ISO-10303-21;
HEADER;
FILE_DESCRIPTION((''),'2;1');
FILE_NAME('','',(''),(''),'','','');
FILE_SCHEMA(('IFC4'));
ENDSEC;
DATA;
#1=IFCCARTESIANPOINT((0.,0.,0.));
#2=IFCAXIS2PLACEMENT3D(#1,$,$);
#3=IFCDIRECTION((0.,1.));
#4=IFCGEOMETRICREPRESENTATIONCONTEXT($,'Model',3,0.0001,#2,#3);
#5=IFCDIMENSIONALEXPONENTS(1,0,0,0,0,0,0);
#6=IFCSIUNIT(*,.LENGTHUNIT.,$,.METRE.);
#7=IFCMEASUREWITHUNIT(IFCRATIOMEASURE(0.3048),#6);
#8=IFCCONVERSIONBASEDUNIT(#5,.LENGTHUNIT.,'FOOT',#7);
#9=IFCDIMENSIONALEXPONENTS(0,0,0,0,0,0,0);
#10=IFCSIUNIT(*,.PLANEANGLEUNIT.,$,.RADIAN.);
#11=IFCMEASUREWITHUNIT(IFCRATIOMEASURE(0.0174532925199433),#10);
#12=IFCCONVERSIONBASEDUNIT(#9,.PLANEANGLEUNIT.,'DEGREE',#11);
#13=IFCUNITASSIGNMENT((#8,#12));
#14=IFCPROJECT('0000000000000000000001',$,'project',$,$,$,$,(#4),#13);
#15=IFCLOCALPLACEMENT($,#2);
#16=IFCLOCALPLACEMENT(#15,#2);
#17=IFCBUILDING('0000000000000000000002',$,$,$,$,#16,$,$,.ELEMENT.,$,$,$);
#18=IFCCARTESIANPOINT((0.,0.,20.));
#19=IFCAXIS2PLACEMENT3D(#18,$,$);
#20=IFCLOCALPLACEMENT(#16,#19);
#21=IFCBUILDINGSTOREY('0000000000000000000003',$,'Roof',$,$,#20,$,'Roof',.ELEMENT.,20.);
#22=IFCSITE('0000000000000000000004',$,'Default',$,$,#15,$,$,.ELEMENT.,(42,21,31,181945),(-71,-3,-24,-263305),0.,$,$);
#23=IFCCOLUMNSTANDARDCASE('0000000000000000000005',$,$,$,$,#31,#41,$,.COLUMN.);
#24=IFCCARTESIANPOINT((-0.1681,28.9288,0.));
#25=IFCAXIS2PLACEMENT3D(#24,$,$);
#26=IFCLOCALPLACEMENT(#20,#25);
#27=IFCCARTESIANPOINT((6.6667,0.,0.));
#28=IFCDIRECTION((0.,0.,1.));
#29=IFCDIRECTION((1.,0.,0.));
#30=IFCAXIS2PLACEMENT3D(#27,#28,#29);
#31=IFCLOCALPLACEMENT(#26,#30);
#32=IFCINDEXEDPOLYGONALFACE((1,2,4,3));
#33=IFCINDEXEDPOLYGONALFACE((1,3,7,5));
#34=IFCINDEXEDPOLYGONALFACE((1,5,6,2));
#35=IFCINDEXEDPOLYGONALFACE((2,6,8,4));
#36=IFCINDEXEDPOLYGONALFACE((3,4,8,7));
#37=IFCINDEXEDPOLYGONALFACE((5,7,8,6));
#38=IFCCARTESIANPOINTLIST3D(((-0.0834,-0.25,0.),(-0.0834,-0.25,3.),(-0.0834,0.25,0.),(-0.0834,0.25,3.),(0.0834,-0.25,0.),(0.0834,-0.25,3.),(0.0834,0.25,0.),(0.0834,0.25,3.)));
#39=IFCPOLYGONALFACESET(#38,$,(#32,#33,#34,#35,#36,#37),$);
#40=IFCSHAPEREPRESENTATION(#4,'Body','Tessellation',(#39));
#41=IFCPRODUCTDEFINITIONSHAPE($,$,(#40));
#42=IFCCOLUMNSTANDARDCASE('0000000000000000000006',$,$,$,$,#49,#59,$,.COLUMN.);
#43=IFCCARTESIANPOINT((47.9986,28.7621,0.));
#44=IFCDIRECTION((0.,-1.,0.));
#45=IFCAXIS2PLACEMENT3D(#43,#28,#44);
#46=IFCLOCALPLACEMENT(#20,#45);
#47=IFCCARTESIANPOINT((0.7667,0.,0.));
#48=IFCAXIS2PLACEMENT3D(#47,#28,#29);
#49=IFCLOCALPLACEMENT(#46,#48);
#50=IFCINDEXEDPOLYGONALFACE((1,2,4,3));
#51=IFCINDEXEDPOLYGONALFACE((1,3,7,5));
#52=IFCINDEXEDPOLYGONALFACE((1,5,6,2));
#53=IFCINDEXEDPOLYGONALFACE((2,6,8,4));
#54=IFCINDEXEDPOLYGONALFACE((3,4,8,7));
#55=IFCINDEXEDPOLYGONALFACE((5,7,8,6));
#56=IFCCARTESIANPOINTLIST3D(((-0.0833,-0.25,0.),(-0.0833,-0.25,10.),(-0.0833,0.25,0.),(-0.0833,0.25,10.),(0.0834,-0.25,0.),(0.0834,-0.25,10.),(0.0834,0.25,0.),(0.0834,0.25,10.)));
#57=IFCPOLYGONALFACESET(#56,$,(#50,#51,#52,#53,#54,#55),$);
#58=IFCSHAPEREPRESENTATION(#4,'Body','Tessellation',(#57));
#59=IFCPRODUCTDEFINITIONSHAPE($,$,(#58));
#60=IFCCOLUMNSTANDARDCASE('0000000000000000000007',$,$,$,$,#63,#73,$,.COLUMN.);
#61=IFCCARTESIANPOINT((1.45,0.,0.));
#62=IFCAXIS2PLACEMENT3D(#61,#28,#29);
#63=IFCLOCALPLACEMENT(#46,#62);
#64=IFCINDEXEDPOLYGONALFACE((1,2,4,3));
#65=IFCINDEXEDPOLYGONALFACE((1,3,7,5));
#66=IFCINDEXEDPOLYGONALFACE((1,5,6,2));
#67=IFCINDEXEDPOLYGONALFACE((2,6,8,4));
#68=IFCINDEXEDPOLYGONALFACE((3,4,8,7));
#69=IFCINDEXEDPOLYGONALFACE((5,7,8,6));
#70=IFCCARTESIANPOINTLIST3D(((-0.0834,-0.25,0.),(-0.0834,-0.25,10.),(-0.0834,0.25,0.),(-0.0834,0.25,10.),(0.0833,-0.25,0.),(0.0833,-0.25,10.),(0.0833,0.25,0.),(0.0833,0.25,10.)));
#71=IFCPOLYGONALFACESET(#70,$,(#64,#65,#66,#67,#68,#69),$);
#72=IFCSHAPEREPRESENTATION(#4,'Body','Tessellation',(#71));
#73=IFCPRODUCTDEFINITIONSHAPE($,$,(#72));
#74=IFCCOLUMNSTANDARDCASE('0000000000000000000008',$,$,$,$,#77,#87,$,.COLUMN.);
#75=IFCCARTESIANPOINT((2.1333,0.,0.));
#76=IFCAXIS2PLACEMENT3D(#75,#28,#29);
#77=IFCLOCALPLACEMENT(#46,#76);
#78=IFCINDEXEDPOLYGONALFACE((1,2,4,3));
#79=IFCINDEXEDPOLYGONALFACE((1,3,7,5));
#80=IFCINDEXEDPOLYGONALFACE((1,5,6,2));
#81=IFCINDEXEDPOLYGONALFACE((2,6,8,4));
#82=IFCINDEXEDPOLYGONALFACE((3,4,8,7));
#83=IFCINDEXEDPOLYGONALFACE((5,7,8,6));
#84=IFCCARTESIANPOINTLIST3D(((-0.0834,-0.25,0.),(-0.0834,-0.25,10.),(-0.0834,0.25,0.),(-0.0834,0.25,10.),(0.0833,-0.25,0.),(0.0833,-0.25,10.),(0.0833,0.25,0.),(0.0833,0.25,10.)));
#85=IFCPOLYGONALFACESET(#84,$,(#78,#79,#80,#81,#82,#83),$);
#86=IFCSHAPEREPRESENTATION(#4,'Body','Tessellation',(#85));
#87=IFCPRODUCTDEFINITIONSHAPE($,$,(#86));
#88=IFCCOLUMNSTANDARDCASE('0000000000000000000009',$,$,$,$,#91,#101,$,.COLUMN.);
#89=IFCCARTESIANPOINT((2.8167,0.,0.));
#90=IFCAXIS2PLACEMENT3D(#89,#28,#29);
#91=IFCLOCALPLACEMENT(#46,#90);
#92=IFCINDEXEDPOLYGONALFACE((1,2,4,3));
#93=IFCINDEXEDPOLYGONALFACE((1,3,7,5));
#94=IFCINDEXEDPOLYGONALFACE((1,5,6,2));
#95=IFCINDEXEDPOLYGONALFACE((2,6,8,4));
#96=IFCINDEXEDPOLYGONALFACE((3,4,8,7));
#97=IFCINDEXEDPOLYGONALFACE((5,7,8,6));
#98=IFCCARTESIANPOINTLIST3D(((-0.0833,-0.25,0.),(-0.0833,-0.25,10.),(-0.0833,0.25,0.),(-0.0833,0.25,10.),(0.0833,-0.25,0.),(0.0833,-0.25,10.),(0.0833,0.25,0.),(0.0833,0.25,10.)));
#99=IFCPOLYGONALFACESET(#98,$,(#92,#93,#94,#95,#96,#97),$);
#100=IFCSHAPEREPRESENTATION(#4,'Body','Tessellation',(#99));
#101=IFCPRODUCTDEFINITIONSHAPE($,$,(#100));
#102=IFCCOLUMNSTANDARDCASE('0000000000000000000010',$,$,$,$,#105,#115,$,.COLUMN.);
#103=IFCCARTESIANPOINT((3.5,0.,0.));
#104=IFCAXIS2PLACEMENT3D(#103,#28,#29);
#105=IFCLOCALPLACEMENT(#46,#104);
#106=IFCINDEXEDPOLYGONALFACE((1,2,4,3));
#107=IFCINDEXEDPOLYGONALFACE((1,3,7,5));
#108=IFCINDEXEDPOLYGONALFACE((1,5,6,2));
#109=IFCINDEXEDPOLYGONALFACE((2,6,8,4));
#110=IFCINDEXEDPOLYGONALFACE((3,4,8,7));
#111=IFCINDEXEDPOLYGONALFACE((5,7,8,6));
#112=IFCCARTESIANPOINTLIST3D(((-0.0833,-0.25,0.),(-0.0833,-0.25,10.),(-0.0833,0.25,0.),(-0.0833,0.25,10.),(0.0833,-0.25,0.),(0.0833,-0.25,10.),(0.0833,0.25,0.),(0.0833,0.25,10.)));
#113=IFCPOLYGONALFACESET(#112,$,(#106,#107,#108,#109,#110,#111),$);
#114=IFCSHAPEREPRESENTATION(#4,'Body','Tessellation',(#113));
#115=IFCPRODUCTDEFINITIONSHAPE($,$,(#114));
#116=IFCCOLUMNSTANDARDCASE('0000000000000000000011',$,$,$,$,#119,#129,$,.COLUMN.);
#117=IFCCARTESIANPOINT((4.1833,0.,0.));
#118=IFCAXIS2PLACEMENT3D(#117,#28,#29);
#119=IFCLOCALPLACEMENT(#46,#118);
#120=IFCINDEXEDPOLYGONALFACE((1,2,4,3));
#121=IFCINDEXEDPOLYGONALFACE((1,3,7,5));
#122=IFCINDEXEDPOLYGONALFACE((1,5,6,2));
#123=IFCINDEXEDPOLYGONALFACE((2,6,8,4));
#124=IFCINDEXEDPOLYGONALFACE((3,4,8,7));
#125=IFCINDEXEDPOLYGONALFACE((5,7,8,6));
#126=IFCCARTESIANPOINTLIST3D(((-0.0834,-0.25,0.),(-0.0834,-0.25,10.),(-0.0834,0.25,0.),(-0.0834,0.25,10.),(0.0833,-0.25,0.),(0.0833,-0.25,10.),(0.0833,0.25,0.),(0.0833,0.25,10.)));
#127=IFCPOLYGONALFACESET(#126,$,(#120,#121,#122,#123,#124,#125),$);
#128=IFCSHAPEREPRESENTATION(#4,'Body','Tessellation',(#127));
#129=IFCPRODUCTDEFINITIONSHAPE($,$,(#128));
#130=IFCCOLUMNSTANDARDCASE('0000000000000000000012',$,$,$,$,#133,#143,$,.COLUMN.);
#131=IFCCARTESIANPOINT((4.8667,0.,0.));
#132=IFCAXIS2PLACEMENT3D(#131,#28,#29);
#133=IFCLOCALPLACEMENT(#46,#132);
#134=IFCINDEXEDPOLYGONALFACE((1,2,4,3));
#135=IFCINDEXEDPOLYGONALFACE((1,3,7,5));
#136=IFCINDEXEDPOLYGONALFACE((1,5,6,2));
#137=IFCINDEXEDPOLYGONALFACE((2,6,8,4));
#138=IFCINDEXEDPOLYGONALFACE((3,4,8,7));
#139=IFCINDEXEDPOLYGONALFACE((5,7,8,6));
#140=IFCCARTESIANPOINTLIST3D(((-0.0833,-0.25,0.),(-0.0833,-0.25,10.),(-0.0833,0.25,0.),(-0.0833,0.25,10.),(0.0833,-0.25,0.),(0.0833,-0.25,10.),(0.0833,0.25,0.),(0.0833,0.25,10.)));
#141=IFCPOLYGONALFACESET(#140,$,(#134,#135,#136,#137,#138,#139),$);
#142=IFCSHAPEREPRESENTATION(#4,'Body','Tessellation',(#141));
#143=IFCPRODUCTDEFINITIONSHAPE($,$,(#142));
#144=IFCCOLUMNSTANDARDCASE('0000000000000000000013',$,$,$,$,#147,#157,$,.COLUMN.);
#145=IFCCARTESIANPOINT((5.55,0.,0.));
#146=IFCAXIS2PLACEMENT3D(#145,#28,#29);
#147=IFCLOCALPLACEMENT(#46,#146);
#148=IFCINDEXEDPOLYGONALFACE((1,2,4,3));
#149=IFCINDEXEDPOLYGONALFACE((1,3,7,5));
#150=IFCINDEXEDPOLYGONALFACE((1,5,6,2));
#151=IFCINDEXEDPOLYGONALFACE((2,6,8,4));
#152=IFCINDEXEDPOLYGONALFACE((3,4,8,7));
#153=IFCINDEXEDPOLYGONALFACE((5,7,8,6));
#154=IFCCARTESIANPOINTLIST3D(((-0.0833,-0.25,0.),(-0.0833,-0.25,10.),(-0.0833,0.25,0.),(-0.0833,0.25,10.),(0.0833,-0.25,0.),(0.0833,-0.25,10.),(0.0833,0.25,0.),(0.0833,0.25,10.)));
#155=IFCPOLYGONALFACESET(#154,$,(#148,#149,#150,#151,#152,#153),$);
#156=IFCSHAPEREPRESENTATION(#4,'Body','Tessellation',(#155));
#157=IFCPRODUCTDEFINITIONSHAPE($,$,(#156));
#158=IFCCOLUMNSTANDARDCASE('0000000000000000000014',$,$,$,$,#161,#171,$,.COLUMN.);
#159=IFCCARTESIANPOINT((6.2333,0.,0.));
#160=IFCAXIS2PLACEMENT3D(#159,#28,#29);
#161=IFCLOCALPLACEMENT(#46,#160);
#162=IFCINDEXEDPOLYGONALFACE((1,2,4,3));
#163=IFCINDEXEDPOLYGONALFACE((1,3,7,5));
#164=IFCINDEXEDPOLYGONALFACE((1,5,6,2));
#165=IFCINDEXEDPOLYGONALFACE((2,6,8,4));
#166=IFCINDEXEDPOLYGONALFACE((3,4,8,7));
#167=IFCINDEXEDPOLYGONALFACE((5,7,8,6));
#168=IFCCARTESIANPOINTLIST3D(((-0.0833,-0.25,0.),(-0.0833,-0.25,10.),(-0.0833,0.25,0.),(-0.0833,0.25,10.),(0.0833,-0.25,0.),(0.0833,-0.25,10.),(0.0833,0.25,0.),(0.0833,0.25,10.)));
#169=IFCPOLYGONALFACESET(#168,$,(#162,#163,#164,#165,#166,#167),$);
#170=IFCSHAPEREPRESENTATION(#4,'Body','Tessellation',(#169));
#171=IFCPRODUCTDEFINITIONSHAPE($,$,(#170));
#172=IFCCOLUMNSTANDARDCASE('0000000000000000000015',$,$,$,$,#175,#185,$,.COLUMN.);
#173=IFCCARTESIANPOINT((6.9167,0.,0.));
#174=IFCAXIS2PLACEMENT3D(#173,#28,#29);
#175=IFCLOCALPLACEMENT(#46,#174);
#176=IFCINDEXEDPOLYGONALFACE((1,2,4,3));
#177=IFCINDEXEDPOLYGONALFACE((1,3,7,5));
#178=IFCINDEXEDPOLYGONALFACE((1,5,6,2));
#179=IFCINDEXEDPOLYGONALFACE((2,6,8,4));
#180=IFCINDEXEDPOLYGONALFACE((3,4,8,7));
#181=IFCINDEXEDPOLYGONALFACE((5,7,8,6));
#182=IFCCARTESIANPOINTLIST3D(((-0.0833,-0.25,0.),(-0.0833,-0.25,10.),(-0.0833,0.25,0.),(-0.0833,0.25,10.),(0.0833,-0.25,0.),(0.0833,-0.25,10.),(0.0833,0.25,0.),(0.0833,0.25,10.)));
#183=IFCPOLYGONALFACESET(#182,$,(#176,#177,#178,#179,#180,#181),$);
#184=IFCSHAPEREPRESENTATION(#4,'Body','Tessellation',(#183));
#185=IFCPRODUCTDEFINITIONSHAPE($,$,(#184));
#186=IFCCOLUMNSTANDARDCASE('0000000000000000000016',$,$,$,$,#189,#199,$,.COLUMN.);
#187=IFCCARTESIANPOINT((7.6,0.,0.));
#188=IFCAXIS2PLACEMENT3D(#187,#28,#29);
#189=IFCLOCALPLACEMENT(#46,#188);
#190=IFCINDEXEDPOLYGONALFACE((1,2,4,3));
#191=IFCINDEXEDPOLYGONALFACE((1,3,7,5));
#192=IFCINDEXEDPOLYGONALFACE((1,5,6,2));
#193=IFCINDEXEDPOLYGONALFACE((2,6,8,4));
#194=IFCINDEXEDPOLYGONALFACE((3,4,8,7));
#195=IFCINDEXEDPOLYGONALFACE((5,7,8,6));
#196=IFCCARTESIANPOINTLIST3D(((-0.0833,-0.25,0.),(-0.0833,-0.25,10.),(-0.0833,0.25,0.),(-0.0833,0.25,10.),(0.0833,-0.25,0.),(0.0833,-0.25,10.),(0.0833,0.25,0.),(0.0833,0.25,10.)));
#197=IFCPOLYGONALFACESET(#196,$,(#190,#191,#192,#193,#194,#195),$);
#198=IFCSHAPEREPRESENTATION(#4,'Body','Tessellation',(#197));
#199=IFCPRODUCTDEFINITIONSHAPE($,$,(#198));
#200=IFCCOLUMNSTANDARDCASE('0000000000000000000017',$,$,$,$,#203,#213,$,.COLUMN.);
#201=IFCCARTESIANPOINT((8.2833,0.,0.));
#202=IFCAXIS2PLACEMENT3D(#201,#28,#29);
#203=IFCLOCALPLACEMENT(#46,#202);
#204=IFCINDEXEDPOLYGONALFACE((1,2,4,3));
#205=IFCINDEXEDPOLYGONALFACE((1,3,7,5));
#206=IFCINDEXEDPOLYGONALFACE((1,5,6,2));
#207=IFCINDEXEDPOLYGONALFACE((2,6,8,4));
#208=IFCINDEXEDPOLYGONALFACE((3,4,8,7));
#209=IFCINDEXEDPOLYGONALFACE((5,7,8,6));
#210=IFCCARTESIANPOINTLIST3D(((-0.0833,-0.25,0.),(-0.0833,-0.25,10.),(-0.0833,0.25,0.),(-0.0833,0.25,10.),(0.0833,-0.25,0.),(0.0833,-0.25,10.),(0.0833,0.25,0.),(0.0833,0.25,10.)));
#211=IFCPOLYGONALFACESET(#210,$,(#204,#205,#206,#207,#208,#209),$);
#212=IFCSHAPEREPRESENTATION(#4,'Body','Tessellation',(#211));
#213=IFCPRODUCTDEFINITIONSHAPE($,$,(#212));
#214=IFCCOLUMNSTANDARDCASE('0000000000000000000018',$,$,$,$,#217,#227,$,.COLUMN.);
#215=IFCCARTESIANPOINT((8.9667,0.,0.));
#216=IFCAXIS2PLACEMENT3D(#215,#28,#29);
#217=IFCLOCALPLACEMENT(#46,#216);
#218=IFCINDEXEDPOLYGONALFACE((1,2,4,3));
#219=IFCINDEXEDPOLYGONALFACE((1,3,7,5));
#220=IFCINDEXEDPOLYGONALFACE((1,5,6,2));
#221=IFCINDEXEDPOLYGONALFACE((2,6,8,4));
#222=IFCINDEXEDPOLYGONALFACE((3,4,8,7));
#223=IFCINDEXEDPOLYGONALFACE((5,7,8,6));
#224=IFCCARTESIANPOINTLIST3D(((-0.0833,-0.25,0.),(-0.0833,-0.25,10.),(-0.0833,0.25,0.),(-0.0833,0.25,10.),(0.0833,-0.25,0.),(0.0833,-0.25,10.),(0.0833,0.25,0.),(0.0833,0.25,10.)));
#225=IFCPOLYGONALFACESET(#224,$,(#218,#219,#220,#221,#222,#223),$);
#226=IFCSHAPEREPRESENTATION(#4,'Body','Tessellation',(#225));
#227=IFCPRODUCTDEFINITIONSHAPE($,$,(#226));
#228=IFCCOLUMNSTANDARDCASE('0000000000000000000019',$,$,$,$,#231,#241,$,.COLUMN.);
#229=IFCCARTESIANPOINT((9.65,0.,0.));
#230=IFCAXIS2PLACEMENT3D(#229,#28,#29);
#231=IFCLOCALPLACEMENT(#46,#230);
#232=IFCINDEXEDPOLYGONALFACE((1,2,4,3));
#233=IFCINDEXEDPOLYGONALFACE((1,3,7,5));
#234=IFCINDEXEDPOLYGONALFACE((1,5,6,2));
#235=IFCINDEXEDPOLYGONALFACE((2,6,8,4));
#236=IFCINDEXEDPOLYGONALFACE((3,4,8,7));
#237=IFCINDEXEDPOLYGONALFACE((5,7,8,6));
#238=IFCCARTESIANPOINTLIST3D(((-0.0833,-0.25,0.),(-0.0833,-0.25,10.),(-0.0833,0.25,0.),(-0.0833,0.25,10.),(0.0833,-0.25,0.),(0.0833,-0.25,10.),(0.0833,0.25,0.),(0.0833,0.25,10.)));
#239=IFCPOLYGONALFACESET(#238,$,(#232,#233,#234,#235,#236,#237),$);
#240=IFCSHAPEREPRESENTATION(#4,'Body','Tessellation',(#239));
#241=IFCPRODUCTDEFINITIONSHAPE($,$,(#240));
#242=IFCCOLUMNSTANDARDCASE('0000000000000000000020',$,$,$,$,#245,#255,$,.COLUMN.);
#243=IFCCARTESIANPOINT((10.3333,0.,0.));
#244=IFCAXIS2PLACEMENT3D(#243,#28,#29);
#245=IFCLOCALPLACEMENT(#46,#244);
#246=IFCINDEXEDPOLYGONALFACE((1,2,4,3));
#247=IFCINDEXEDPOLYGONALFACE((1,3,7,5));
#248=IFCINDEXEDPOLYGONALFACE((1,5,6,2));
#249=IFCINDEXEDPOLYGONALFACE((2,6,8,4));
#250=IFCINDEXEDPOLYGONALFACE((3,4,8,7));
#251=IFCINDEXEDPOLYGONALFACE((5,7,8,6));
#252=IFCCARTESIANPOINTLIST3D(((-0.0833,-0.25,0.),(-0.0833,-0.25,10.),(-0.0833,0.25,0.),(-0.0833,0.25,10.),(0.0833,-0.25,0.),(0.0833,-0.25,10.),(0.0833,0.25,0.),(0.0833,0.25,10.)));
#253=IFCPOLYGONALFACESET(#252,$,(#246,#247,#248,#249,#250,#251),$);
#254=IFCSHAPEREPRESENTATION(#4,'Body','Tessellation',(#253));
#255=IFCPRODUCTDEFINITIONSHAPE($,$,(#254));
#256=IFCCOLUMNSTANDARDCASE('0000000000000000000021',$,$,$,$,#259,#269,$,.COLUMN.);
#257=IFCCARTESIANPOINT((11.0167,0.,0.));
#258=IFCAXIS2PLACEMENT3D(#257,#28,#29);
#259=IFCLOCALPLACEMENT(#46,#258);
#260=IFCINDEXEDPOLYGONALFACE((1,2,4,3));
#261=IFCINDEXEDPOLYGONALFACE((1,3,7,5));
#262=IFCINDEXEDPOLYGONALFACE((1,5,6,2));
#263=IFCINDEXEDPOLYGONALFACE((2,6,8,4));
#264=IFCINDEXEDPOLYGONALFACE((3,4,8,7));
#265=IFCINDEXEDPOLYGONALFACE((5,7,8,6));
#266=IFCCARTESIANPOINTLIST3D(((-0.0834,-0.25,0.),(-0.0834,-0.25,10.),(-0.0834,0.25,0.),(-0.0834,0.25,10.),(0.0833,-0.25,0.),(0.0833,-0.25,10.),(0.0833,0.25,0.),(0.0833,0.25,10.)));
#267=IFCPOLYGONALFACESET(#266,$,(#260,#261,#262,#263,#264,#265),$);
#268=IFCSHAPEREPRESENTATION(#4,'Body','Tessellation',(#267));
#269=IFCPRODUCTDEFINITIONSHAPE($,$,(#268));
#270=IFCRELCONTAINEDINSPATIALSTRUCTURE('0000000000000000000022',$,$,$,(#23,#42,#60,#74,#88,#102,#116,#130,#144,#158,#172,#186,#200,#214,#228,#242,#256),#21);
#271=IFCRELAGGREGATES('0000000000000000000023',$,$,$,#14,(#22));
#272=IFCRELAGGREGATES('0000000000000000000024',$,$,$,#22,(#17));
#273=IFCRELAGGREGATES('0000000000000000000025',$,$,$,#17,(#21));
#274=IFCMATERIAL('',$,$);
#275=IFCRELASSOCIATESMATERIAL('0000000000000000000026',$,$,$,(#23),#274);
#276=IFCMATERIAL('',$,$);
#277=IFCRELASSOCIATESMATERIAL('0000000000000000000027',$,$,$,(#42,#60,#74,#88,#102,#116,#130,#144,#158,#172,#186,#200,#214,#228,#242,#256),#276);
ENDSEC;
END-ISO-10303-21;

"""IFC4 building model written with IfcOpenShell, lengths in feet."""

from ifc_helpers import new_model, entity, si_unit, converted_unit, direction, frame, origin, place, context, project, spatial, rectangle, extrude, material, element, save


model = new_model("IFC4")

# Units and contexts
model_context = context("Model", 3, precision=0.0001, world=origin(), true_north=direction((0.0, 1.0)))
ifc_project = project(units=[converted_unit("LENGTHUNIT", "FOOT", entity("IfcRatioMeasure", 0.3048), si_unit("LENGTHUNIT", "METRE"), dimensions=[1, 0, 0, 0, 0, 0, 0]), converted_unit("PLANEANGLEUNIT", "DEGREE", entity("IfcRatioMeasure", 0.0174532925199433), si_unit("PLANEANGLEUNIT", "RADIAN"), dimensions=[0, 0, 0, 0, 0, 0, 0])], contexts=[model_context])

# Site, building, storey
site_placement = place(None, origin())
site = spatial("IfcSite", under=ifc_project, at=site_placement, Name="Default", CompositionType="ELEMENT", RefLatitude=(42, 21, 31, 181945), RefLongitude=(-71, -3, -24, -263305), RefElevation=0.0)
building_placement = place(site_placement, origin())
building = spatial("IfcBuilding", under=site, at=building_placement, CompositionType="ELEMENT")
storey_placement = place(building_placement, frame((0.0, 0.0, 20.0)))
storey = spatial("IfcBuildingStorey", under=building, at=storey_placement, Name="Roof", LongName="Roof", CompositionType="ELEMENT", Elevation=20.0)

# Columns
ifc_material_1 = material(Name="")
placement = place(storey_placement, frame((-0.1681, 28.9288, 0.0)))
for number, where, z_axis, x_axis in (
    (1, (6.6667, 0.0, 0.0), (0.0, 0.0, 1.0), (1.0, 0.0, 0.0)),
):
    element("IfcColumnStandardCase", number, at=place(placement, frame(where, z_axis=z_axis, x_axis=x_axis)), inside=storey, material=ifc_material_1, PredefinedType="COLUMN", context=model_context, shape_type="SweptSolid", body=[
        extrude(rectangle(XDim=0.1667, YDim=0.5), origin(), (0.0, 0.0, 1.0), 3.0),
    ])
ifc_material_2 = material(Name="")
wall_placement = place(storey_placement, frame((47.9986, 28.7621, 0.0), z_axis=(0.0, 0.0, 1.0), x_axis=(0.0, -1.0, 0.0)))
for number, where, z_axis, x_axis in (
    (2, (0.7667, 0.0, 0.0), (0.0, 0.0, 1.0), (1.0, 0.0, 0.0)),
    (3, (1.45, 0.0, 0.0), (0.0, 0.0, 1.0), (1.0, 0.0, 0.0)),
    (4, (2.1333, 0.0, 0.0), (0.0, 0.0, 1.0), (1.0, 0.0, 0.0)),
    (5, (2.8167, 0.0, 0.0), (0.0, 0.0, 1.0), (1.0, 0.0, 0.0)),
    (6, (3.5, 0.0, 0.0), (0.0, 0.0, 1.0), (1.0, 0.0, 0.0)),
    (7, (4.1833, 0.0, 0.0), (0.0, 0.0, 1.0), (1.0, 0.0, 0.0)),
    (8, (4.8667, 0.0, 0.0), (0.0, 0.0, 1.0), (1.0, 0.0, 0.0)),
    (9, (5.55, 0.0, 0.0), (0.0, 0.0, 1.0), (1.0, 0.0, 0.0)),
    (10, (6.2333, 0.0, 0.0), (0.0, 0.0, 1.0), (1.0, 0.0, 0.0)),
    (11, (6.9167, 0.0, 0.0), (0.0, 0.0, 1.0), (1.0, 0.0, 0.0)),
    (12, (7.6, 0.0, 0.0), (0.0, 0.0, 1.0), (1.0, 0.0, 0.0)),
    (13, (8.2833, 0.0, 0.0), (0.0, 0.0, 1.0), (1.0, 0.0, 0.0)),
    (14, (8.9667, 0.0, 0.0), (0.0, 0.0, 1.0), (1.0, 0.0, 0.0)),
    (15, (9.65, 0.0, 0.0), (0.0, 0.0, 1.0), (1.0, 0.0, 0.0)),
    (16, (10.3333, 0.0, 0.0), (0.0, 0.0, 1.0), (1.0, 0.0, 0.0)),
    (17, (11.0167, 0.0, 0.0), (0.0, 0.0, 1.0), (1.0, 0.0, 0.0)),
):
    element("IfcColumnStandardCase", number, at=place(wall_placement, frame(where, z_axis=z_axis, x_axis=x_axis)), inside=storey, material=ifc_material_2, PredefinedType="COLUMN", context=model_context, shape_type="SweptSolid", body=[
        extrude(rectangle(XDim=0.1667, YDim=0.5), origin(), (0.0, 0.0, 1.0), 10.0),
    ])

save(model, "model.ifc")
